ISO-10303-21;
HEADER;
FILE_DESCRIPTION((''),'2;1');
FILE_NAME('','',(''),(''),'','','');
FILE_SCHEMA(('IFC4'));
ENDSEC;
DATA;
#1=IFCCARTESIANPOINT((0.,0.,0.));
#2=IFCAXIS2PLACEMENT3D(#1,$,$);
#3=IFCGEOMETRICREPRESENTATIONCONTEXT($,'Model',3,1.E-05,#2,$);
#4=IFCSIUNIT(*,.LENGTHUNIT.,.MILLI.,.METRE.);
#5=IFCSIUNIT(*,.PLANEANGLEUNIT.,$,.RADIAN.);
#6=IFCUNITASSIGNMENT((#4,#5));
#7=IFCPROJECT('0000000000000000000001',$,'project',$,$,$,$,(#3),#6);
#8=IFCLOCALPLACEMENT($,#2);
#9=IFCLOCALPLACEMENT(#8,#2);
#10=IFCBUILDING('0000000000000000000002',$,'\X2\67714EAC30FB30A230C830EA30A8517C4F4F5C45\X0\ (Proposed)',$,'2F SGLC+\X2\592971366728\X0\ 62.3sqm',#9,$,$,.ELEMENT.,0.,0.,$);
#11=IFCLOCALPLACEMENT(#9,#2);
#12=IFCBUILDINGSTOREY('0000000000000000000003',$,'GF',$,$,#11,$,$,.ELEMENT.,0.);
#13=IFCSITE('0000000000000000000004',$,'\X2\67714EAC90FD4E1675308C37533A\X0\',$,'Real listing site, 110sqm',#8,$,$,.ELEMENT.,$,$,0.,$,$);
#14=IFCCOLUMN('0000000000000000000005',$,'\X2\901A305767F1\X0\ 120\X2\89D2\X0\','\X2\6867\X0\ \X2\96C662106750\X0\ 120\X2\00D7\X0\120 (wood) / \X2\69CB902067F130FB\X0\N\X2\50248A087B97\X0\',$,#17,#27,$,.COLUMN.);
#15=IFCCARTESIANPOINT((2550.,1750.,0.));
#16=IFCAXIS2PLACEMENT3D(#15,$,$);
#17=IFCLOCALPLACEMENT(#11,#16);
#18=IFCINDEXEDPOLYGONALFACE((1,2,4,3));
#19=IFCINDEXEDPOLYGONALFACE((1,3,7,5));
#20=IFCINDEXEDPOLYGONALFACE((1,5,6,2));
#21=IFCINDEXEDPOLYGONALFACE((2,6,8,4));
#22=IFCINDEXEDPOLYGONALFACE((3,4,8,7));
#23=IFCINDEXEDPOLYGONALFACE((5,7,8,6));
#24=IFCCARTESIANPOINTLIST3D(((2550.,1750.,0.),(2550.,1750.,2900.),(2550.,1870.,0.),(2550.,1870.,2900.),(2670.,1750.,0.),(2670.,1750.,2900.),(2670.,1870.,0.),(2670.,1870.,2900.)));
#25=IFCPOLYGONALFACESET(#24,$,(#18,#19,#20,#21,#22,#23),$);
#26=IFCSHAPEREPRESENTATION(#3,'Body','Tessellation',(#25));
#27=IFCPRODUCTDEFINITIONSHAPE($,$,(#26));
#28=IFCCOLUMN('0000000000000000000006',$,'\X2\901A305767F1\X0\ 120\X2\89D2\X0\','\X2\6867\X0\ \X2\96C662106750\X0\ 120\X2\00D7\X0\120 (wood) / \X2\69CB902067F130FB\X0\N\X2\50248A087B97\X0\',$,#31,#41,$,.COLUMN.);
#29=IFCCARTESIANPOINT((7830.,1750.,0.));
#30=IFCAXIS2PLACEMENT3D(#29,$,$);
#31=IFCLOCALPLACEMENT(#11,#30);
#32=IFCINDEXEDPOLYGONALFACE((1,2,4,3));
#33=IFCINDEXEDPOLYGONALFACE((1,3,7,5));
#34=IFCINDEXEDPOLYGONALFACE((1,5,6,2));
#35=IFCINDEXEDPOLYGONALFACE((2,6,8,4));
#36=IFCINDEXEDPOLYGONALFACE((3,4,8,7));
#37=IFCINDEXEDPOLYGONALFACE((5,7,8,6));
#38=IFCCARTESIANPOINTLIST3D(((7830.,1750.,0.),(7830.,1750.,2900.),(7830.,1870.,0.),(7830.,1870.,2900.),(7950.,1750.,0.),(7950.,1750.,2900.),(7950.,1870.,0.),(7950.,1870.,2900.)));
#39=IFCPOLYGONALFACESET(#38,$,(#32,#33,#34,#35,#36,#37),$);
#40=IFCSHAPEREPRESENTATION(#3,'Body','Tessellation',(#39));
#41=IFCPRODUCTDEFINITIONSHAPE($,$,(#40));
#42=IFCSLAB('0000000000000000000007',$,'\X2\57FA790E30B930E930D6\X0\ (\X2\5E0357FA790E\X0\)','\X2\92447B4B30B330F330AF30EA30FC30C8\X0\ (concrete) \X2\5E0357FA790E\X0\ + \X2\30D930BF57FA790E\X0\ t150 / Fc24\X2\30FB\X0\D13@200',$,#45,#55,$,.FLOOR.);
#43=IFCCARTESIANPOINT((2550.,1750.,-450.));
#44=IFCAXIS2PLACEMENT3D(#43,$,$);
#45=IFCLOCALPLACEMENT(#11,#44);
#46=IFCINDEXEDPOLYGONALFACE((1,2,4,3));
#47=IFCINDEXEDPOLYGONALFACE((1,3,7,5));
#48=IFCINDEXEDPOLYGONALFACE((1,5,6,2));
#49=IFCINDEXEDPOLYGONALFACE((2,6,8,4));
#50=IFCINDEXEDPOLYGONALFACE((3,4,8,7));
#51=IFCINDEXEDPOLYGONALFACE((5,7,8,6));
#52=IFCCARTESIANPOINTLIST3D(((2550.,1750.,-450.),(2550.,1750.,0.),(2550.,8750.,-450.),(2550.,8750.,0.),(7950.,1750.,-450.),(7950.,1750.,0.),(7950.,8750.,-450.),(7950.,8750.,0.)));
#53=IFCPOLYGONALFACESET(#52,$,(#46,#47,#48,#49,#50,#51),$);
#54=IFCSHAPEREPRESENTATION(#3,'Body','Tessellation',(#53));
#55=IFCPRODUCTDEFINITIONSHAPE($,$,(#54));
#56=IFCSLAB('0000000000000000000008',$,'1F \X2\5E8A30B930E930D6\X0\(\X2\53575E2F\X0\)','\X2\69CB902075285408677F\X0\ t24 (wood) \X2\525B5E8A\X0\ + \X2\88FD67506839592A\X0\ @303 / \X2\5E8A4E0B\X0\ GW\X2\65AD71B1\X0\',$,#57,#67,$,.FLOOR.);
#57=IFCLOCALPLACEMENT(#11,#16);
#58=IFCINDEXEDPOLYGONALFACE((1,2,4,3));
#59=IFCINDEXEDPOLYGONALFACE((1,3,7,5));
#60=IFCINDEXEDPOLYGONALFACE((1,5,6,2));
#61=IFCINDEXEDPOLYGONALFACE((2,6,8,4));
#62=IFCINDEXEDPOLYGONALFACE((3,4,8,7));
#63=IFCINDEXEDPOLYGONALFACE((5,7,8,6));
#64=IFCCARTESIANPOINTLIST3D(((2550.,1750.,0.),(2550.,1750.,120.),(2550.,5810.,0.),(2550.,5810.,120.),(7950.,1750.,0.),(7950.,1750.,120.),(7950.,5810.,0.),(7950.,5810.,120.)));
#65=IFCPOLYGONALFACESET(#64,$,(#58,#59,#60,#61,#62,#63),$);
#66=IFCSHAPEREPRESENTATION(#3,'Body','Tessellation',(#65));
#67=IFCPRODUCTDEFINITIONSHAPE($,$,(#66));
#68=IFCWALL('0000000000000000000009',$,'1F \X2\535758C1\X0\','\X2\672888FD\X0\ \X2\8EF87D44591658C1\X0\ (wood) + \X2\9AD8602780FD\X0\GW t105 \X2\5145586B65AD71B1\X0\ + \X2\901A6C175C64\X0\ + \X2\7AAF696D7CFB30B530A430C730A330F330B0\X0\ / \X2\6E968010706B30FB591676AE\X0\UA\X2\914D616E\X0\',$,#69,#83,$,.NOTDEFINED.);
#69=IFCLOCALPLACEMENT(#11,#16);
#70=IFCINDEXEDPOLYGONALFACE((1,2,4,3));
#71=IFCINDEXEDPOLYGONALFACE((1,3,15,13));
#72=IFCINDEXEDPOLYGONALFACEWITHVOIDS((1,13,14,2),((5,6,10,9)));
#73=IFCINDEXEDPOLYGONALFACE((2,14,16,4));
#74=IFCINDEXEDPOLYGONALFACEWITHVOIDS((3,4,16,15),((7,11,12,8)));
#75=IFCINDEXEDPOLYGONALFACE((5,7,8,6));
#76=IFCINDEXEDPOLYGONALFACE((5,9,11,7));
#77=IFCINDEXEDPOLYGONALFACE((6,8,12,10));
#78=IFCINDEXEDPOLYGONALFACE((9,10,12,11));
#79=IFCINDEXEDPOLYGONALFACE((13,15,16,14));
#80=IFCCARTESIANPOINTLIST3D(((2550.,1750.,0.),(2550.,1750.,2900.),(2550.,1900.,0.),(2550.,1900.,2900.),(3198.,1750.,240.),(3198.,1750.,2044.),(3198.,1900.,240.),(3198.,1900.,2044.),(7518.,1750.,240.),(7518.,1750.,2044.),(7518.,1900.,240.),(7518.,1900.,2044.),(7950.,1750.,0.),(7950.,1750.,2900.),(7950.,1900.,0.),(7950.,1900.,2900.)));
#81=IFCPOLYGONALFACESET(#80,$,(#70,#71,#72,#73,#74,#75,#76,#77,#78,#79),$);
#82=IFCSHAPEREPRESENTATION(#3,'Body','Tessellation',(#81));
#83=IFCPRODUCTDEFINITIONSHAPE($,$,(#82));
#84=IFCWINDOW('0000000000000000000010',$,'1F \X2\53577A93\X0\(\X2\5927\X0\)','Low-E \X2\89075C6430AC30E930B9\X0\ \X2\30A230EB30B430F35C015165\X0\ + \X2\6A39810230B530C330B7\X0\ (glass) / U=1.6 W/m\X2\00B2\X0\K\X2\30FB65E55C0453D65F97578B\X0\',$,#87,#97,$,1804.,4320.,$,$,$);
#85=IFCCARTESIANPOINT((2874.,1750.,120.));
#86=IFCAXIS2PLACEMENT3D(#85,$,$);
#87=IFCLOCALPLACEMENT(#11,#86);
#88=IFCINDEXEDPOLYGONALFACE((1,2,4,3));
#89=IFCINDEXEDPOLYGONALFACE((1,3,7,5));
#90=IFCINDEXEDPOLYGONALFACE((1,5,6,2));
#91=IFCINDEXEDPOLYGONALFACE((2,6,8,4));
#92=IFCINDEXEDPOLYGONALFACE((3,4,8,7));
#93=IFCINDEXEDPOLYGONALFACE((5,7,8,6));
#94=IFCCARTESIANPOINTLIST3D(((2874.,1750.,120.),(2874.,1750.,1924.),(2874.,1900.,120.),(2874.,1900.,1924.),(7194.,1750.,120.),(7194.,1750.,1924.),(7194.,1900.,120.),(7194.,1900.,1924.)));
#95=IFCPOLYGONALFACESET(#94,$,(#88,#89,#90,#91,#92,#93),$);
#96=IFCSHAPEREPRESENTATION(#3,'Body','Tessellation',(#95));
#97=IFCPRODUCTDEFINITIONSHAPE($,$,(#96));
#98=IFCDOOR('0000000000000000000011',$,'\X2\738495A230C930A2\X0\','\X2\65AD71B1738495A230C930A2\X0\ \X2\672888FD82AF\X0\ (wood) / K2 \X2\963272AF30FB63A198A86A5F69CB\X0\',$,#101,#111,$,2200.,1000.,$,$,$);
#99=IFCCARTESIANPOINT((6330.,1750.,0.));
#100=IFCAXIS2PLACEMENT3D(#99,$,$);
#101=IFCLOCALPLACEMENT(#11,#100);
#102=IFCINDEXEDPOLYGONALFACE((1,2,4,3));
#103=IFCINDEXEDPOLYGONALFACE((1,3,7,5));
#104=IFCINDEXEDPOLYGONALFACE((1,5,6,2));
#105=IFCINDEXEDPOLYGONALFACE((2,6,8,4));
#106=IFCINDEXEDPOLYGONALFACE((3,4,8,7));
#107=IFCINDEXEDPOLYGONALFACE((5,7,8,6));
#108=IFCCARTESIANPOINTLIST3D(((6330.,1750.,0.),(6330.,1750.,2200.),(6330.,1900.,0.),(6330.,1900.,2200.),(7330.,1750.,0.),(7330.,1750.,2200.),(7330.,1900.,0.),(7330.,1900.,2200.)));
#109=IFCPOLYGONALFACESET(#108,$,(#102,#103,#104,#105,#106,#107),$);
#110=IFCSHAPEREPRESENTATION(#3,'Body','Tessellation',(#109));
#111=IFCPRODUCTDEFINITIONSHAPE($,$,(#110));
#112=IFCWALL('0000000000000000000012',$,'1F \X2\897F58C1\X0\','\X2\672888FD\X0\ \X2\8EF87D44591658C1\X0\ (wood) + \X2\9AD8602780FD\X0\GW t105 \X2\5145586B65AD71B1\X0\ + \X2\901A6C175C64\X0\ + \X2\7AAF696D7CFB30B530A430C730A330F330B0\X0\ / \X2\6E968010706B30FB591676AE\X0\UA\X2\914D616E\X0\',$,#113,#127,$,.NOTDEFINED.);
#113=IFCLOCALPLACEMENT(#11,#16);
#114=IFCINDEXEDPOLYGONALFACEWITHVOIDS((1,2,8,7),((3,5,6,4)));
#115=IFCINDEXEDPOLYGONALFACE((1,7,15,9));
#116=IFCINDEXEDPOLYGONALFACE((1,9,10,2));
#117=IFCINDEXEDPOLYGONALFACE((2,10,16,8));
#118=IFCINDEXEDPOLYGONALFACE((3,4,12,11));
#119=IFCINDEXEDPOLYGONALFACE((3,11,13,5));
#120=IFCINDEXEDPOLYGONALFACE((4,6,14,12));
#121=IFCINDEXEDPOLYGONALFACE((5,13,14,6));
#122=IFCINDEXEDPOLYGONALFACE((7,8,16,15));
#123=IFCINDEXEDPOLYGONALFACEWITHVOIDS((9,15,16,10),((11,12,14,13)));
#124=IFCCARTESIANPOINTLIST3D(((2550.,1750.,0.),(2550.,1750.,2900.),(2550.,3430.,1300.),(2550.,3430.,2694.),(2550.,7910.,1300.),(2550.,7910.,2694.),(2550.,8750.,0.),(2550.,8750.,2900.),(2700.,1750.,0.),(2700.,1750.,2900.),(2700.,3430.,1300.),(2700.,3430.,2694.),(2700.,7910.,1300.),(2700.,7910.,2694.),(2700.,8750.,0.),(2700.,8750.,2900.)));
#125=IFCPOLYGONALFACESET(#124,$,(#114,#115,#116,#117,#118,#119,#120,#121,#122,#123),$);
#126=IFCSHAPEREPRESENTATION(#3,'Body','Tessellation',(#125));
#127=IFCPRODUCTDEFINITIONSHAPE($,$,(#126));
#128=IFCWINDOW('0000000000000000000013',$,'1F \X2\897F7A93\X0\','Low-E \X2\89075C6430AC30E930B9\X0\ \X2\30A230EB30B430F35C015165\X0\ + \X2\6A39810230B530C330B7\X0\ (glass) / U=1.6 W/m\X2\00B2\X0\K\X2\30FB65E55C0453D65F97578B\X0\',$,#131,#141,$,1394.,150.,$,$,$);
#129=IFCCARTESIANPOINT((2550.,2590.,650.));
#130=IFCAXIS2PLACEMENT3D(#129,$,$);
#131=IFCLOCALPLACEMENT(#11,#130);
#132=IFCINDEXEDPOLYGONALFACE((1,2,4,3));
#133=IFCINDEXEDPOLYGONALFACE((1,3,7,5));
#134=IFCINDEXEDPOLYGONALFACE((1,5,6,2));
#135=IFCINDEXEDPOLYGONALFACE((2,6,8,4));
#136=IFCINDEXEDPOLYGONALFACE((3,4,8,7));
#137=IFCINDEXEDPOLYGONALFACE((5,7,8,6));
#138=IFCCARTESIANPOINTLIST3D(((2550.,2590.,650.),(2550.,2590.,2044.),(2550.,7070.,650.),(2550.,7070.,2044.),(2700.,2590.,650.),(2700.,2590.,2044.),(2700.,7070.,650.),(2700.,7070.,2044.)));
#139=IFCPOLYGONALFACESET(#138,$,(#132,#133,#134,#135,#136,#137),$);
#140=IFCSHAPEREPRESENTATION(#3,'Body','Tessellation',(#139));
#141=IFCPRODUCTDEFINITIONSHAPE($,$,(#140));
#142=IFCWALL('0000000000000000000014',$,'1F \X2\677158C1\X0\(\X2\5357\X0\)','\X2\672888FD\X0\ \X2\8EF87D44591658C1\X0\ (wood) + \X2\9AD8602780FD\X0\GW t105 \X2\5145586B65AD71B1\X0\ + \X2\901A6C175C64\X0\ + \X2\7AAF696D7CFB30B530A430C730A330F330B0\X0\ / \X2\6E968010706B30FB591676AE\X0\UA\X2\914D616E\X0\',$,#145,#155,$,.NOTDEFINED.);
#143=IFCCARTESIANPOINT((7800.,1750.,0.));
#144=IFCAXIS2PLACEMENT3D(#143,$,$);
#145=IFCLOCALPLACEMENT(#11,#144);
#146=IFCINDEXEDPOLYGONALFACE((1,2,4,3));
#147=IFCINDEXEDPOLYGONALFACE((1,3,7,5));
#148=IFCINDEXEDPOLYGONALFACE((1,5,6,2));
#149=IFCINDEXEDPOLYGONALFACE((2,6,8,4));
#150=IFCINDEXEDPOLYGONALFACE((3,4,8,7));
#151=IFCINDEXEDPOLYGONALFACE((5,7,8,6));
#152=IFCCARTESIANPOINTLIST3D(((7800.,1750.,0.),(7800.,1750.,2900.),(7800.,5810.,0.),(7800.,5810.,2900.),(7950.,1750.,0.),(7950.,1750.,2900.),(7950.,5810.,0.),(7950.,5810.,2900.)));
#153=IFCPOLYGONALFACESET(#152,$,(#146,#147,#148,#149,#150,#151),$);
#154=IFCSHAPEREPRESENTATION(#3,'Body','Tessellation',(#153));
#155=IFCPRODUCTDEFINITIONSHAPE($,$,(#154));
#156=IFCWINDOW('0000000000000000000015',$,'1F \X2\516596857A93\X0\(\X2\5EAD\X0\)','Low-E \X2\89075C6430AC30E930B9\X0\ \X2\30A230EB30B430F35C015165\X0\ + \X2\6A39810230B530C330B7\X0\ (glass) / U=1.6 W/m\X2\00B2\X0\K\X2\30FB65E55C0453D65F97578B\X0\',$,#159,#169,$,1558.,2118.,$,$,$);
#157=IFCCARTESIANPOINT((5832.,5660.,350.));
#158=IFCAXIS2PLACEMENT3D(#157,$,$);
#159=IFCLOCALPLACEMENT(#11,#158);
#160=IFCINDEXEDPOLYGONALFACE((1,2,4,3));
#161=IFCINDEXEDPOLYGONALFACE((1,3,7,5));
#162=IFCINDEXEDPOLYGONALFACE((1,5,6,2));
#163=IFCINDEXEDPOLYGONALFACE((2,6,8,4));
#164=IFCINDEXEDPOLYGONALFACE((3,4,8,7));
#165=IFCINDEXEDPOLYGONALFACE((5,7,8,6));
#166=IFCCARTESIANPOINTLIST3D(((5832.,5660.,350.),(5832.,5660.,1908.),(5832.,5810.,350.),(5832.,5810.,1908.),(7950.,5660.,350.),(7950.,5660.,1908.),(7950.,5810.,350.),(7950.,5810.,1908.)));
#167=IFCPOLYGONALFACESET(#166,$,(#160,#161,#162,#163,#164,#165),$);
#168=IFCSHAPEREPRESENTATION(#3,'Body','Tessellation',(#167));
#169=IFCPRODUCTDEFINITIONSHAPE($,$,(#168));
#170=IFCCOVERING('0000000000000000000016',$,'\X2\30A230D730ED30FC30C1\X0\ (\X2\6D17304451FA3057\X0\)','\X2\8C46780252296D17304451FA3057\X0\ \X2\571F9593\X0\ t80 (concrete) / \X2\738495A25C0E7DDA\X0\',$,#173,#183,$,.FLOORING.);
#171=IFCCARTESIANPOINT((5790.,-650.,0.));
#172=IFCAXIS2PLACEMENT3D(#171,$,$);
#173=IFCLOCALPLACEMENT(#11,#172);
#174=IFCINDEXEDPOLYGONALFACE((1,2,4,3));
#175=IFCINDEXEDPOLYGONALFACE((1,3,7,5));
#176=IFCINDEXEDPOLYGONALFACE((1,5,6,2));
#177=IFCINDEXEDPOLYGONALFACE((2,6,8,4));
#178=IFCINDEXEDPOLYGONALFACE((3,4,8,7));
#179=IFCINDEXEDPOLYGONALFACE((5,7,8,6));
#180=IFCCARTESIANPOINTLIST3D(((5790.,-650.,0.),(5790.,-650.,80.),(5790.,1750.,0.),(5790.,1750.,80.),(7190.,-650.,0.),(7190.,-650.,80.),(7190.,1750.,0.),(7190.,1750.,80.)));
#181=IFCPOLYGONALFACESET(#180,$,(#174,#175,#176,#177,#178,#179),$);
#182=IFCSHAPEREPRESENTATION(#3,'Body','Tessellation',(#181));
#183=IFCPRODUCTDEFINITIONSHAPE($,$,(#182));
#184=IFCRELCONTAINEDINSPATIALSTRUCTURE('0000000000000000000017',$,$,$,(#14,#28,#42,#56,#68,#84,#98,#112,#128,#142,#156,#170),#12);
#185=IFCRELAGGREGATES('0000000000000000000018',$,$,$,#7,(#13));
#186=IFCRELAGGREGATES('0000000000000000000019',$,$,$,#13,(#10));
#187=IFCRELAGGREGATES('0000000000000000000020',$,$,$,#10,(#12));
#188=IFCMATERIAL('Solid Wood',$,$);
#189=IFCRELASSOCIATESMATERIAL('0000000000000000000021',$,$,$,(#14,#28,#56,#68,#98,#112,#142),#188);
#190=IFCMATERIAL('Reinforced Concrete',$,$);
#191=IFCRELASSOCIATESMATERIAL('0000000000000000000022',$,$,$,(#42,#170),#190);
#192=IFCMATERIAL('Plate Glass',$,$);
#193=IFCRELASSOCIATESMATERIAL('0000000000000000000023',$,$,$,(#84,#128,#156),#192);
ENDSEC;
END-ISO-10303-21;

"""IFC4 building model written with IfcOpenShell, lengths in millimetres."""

from ifc_helpers import new_model, si_unit, frame, frame_2d, origin, place, context, project, spatial, rectangle, extrude, material, element, fill, save


model = new_model("IFC4")

# Units and contexts
model_context = context("Model", 3, precision=1e-05, world=origin())
ifc_project = project(units=[si_unit("LENGTHUNIT", "METRE", prefix="MILLI"), si_unit("PLANEANGLEUNIT", "RADIAN")], contexts=[model_context])

# Site, building, storey
site_placement = place(None, origin())
site = spatial("IfcSite", under=ifc_project, at=site_placement, Name="東京都世田谷区", ObjectType="Real listing site, 110sqm", CompositionType="ELEMENT", RefElevation=0.0)
building_placement = place(site_placement, origin())
building = spatial("IfcBuilding", under=site, at=building_placement, Name="東京・アトリエ兼住居 (Proposed)", ObjectType="2F SGLC+天然木 62.3sqm", CompositionType="ELEMENT", ElevationOfRefHeight=0.0, ElevationOfTerrain=0.0)
storey_placement = place(building_placement, origin())
storey = spatial("IfcBuildingStorey", under=building, at=storey_placement, Name="GF", CompositionType="ELEMENT", Elevation=0.0)

# Columns
ifc_material_1 = material(Name="Solid Wood")
column_1_placement = place(storey_placement, frame((2550.0, 1750.0, 0.0)))
element("IfcColumn", 1, at=column_1_placement, inside=storey, material=ifc_material_1, Name="通し柱 120角", Description="桧 集成材 120×120 (wood) / 構造柱・N値計算", PredefinedType="COLUMN", context=model_context, shape_type="SweptSolid", body=[
    extrude(rectangle(XDim=120.0, YDim=120.0, at=frame_2d((60.0, 60.0))), frame((2550.0, 1750.0, 0.0)), (0.0, 0.0, 1.0), 2900.0),
])
column_2_placement = place(storey_placement, frame((7830.0, 1750.0, 0.0)))
element("IfcColumn", 2, at=column_2_placement, inside=storey, material=ifc_material_1, Name="通し柱 120角", Description="桧 集成材 120×120 (wood) / 構造柱・N値計算", PredefinedType="COLUMN", context=model_context, shape_type="SweptSolid", body=[
    extrude(rectangle(XDim=120.0, YDim=120.0, at=frame_2d((60.0, 60.0))), frame((7830.0, 1750.0, 0.0)), (0.0, 0.0, 1.0), 2900.0),
])

# Slabs
ifc_material_2 = material(Name="Reinforced Concrete")
slab_1_placement = place(storey_placement, frame((2550.0, 1750.0, -450.0)))
element("IfcSlab", 3, at=slab_1_placement, inside=storey, material=ifc_material_2, Name="基礎スラブ (布基礎)", Description="鉄筋コンクリート (concrete) 布基礎 + ベタ基礎 t150 / Fc24・D13@200", PredefinedType="FLOOR", context=model_context, shape_type="SweptSolid", body=[
    extrude(rectangle(XDim=5400.0, YDim=7000.0, at=frame_2d((2700.0, 3500.0))), frame((2550.0, 1750.0, -450.0)), (0.0, 0.0, 1.0), 450.0),
])
slab_2_placement = place(storey_placement, frame((2550.0, 1750.0, 0.0)))
element("IfcSlab", 4, at=slab_2_placement, inside=storey, material=ifc_material_1, Name="1F 床スラブ(南帯)", Description="構造用合板 t24 (wood) 剛床 + 製材根太 @303 / 床下 GW断熱", PredefinedType="FLOOR", context=model_context, shape_type="SweptSolid", body=[
    extrude(rectangle(XDim=5400.0, YDim=4060.0, at=frame_2d((2700.0, 2030.0))), frame((2550.0, 1750.0, 0.0)), (0.0, 0.0, 1.0), 120.0),
])

# Wall, openings, window, door
wall_1_placement = place(storey_placement, frame((2550.0, 1750.0, 0.0)))
wall_1 = element("IfcWall", 5, at=wall_1_placement, inside=storey, material=ifc_material_1, Name="1F 南壁", Description="木製 軸組外壁 (wood) + 高性能GW t105 充填断熱 + 通気層 + 窯業系サイディング / 準耐火・外皮UA配慮", PredefinedType="NOTDEFINED", context=model_context, shape_type="SweptSolid", body=[
    extrude(rectangle(XDim=5400.0, YDim=150.0, at=frame_2d((2700.0, 75.0))), frame((2550.0, 1750.0, 0.0)), (0.0, 0.0, 1.0), 2900.0),
])
opening_1_placement = place(storey_placement, frame((2874.0, 1750.0, 120.0)))
opening_1 = element("IfcOpeningElement", 6, at=opening_1_placement, cuts=wall_1, PredefinedType="NOTDEFINED", context=model_context, shape_type="SweptSolid", body=[
    extrude(rectangle(XDim=4320.0, YDim=150.0, at=frame_2d((2160.0, 75.0))), frame((2874.0, 1750.0, 120.0)), (0.0, 0.0, 1.0), 1804.0),
])
opening_2_placement = place(storey_placement, frame((6330.0, 1750.0, 0.0)))
opening_2 = element("IfcOpeningElement", 7, at=opening_2_placement, cuts=wall_1, PredefinedType="NOTDEFINED", context=model_context, shape_type="SweptSolid", body=[
    extrude(rectangle(XDim=1000.0, YDim=150.0, at=frame_2d((500.0, 75.0))), frame((6330.0, 1750.0, 0.0)), (0.0, 0.0, 1.0), 2200.0),
])
ifc_material_3 = material(Name="Plate Glass")
window_1_placement = place(storey_placement, frame((2874.0, 1750.0, 120.0)))
window_1 = element("IfcWindow", 8, at=window_1_placement, inside=storey, material=ifc_material_3, Name="1F 南窓(大)", Description="Low-E 複層ガラス アルゴン封入 + 樹脂サッシ (glass) / U=1.6 W/m²K・日射取得型", OverallHeight=1804.0, OverallWidth=4320.0, context=model_context, shape_type="SweptSolid", body=[
    extrude(rectangle(XDim=4320.0, YDim=150.0, at=frame_2d((2160.0, 75.0))), frame((2874.0, 1750.0, 120.0)), (0.0, 0.0, 1.0), 1804.0),
])
fill(opening_1, window_1)
door_1_placement = place(storey_placement, frame((6330.0, 1750.0, 0.0)))
door_1 = element("IfcDoor", 9, at=door_1_placement, inside=storey, material=ifc_material_1, Name="玄関ドア", Description="断熱玄関ドア 木製芯 (wood) / K2 防犯・採風機構", OverallHeight=2200.0, OverallWidth=1000.0, context=model_context, shape_type="SweptSolid", body=[
    extrude(rectangle(XDim=1000.0, YDim=150.0, at=frame_2d((500.0, 75.0))), frame((6330.0, 1750.0, 0.0)), (0.0, 0.0, 1.0), 2200.0),
])
fill(opening_2, door_1)

# Walls, openings, windows
wall_2_placement = place(storey_placement, frame((2550.0, 1750.0, 0.0)))
wall_2 = element("IfcWall", 10, at=wall_2_placement, inside=storey, material=ifc_material_1, Name="1F 西壁", Description="木製 軸組外壁 (wood) + 高性能GW t105 充填断熱 + 通気層 + 窯業系サイディング / 準耐火・外皮UA配慮", PredefinedType="NOTDEFINED", context=model_context, shape_type="SweptSolid", body=[
    extrude(rectangle(XDim=150.0, YDim=7000.0, at=frame_2d((75.0, 3500.0))), frame((2550.0, 1750.0, 0.0)), (0.0, 0.0, 1.0), 2900.0),
])
opening_3_placement = place(storey_placement, frame((2550.0, 2590.0, 650.0)))
opening_3 = element("IfcOpeningElement", 11, at=opening_3_placement, cuts=wall_2, PredefinedType="NOTDEFINED", context=model_context, shape_type="SweptSolid", body=[
    extrude(rectangle(XDim=150.0, YDim=4480.0, at=frame_2d((75.0, 2240.0))), frame((2550.0, 2590.0, 650.0)), (0.0, 0.0, 1.0), 1394.0),
])
window_2_placement = place(storey_placement, frame((2550.0, 2590.0, 650.0)))
window_2 = element("IfcWindow", 12, at=window_2_placement, inside=storey, material=ifc_material_3, Name="1F 西窓", Description="Low-E 複層ガラス アルゴン封入 + 樹脂サッシ (glass) / U=1.6 W/m²K・日射取得型", OverallHeight=1394.0, OverallWidth=150.0, context=model_context, shape_type="SweptSolid", body=[
    extrude(rectangle(XDim=150.0, YDim=4480.0, at=frame_2d((75.0, 2240.0))), frame((2550.0, 2590.0, 650.0)), (0.0, 0.0, 1.0), 1394.0),
])
fill(opening_3, window_2)
wall_3_placement = place(storey_placement, frame((7800.0, 1750.0, 0.0)))
wall_3 = element("IfcWall", 13, at=wall_3_placement, inside=storey, material=ifc_material_1, Name="1F 東壁(南)", Description="木製 軸組外壁 (wood) + 高性能GW t105 充填断熱 + 通気層 + 窯業系サイディング / 準耐火・外皮UA配慮", PredefinedType="NOTDEFINED", context=model_context, shape_type="SweptSolid", body=[
    extrude(rectangle(XDim=150.0, YDim=4060.0, at=frame_2d((75.0, 2030.0))), frame((7800.0, 1750.0, 0.0)), (0.0, 0.0, 1.0), 2900.0),
])
opening_4_placement = place(storey_placement, frame((5832.0, 5660.0, 350.0)))
opening_4 = element("IfcOpeningElement", 14, at=opening_4_placement, cuts=wall_3, PredefinedType="NOTDEFINED", context=model_context, shape_type="SweptSolid", body=[
    extrude(rectangle(XDim=2118.0, YDim=150.0, at=frame_2d((1059.0, 75.0))), frame((5832.0, 5660.0, 350.0)), (0.0, 0.0, 1.0), 1558.0),
])
window_3_placement = place(storey_placement, frame((5832.0, 5660.0, 350.0)))
window_3 = element("IfcWindow", 15, at=window_3_placement, inside=storey, material=ifc_material_3, Name="1F 入隅窓(庭)", Description="Low-E 複層ガラス アルゴン封入 + 樹脂サッシ (glass) / U=1.6 W/m²K・日射取得型", OverallHeight=1558.0, OverallWidth=2118.0, context=model_context, shape_type="SweptSolid", body=[
    extrude(rectangle(XDim=2118.0, YDim=150.0, at=frame_2d((1059.0, 75.0))), frame((5832.0, 5660.0, 350.0)), (0.0, 0.0, 1.0), 1558.0),
])
fill(opening_4, window_3)

# Covering
covering_1_placement = place(storey_placement, frame((5790.0, -650.0, 0.0)))
element("IfcCovering", 16, at=covering_1_placement, inside=storey, material=ifc_material_2, Name="アプローチ (洗い出し)", Description="豆砂利洗い出し 土間 t80 (concrete) / 玄関導線", PredefinedType="FLOORING", context=model_context, shape_type="SweptSolid", body=[
    extrude(rectangle(XDim=1400.0, YDim=2400.0, at=frame_2d((700.0, 1200.0))), frame((5790.0, -650.0, 0.0)), (0.0, 0.0, 1.0), 80.0),
])

save(model, "model.ifc")
